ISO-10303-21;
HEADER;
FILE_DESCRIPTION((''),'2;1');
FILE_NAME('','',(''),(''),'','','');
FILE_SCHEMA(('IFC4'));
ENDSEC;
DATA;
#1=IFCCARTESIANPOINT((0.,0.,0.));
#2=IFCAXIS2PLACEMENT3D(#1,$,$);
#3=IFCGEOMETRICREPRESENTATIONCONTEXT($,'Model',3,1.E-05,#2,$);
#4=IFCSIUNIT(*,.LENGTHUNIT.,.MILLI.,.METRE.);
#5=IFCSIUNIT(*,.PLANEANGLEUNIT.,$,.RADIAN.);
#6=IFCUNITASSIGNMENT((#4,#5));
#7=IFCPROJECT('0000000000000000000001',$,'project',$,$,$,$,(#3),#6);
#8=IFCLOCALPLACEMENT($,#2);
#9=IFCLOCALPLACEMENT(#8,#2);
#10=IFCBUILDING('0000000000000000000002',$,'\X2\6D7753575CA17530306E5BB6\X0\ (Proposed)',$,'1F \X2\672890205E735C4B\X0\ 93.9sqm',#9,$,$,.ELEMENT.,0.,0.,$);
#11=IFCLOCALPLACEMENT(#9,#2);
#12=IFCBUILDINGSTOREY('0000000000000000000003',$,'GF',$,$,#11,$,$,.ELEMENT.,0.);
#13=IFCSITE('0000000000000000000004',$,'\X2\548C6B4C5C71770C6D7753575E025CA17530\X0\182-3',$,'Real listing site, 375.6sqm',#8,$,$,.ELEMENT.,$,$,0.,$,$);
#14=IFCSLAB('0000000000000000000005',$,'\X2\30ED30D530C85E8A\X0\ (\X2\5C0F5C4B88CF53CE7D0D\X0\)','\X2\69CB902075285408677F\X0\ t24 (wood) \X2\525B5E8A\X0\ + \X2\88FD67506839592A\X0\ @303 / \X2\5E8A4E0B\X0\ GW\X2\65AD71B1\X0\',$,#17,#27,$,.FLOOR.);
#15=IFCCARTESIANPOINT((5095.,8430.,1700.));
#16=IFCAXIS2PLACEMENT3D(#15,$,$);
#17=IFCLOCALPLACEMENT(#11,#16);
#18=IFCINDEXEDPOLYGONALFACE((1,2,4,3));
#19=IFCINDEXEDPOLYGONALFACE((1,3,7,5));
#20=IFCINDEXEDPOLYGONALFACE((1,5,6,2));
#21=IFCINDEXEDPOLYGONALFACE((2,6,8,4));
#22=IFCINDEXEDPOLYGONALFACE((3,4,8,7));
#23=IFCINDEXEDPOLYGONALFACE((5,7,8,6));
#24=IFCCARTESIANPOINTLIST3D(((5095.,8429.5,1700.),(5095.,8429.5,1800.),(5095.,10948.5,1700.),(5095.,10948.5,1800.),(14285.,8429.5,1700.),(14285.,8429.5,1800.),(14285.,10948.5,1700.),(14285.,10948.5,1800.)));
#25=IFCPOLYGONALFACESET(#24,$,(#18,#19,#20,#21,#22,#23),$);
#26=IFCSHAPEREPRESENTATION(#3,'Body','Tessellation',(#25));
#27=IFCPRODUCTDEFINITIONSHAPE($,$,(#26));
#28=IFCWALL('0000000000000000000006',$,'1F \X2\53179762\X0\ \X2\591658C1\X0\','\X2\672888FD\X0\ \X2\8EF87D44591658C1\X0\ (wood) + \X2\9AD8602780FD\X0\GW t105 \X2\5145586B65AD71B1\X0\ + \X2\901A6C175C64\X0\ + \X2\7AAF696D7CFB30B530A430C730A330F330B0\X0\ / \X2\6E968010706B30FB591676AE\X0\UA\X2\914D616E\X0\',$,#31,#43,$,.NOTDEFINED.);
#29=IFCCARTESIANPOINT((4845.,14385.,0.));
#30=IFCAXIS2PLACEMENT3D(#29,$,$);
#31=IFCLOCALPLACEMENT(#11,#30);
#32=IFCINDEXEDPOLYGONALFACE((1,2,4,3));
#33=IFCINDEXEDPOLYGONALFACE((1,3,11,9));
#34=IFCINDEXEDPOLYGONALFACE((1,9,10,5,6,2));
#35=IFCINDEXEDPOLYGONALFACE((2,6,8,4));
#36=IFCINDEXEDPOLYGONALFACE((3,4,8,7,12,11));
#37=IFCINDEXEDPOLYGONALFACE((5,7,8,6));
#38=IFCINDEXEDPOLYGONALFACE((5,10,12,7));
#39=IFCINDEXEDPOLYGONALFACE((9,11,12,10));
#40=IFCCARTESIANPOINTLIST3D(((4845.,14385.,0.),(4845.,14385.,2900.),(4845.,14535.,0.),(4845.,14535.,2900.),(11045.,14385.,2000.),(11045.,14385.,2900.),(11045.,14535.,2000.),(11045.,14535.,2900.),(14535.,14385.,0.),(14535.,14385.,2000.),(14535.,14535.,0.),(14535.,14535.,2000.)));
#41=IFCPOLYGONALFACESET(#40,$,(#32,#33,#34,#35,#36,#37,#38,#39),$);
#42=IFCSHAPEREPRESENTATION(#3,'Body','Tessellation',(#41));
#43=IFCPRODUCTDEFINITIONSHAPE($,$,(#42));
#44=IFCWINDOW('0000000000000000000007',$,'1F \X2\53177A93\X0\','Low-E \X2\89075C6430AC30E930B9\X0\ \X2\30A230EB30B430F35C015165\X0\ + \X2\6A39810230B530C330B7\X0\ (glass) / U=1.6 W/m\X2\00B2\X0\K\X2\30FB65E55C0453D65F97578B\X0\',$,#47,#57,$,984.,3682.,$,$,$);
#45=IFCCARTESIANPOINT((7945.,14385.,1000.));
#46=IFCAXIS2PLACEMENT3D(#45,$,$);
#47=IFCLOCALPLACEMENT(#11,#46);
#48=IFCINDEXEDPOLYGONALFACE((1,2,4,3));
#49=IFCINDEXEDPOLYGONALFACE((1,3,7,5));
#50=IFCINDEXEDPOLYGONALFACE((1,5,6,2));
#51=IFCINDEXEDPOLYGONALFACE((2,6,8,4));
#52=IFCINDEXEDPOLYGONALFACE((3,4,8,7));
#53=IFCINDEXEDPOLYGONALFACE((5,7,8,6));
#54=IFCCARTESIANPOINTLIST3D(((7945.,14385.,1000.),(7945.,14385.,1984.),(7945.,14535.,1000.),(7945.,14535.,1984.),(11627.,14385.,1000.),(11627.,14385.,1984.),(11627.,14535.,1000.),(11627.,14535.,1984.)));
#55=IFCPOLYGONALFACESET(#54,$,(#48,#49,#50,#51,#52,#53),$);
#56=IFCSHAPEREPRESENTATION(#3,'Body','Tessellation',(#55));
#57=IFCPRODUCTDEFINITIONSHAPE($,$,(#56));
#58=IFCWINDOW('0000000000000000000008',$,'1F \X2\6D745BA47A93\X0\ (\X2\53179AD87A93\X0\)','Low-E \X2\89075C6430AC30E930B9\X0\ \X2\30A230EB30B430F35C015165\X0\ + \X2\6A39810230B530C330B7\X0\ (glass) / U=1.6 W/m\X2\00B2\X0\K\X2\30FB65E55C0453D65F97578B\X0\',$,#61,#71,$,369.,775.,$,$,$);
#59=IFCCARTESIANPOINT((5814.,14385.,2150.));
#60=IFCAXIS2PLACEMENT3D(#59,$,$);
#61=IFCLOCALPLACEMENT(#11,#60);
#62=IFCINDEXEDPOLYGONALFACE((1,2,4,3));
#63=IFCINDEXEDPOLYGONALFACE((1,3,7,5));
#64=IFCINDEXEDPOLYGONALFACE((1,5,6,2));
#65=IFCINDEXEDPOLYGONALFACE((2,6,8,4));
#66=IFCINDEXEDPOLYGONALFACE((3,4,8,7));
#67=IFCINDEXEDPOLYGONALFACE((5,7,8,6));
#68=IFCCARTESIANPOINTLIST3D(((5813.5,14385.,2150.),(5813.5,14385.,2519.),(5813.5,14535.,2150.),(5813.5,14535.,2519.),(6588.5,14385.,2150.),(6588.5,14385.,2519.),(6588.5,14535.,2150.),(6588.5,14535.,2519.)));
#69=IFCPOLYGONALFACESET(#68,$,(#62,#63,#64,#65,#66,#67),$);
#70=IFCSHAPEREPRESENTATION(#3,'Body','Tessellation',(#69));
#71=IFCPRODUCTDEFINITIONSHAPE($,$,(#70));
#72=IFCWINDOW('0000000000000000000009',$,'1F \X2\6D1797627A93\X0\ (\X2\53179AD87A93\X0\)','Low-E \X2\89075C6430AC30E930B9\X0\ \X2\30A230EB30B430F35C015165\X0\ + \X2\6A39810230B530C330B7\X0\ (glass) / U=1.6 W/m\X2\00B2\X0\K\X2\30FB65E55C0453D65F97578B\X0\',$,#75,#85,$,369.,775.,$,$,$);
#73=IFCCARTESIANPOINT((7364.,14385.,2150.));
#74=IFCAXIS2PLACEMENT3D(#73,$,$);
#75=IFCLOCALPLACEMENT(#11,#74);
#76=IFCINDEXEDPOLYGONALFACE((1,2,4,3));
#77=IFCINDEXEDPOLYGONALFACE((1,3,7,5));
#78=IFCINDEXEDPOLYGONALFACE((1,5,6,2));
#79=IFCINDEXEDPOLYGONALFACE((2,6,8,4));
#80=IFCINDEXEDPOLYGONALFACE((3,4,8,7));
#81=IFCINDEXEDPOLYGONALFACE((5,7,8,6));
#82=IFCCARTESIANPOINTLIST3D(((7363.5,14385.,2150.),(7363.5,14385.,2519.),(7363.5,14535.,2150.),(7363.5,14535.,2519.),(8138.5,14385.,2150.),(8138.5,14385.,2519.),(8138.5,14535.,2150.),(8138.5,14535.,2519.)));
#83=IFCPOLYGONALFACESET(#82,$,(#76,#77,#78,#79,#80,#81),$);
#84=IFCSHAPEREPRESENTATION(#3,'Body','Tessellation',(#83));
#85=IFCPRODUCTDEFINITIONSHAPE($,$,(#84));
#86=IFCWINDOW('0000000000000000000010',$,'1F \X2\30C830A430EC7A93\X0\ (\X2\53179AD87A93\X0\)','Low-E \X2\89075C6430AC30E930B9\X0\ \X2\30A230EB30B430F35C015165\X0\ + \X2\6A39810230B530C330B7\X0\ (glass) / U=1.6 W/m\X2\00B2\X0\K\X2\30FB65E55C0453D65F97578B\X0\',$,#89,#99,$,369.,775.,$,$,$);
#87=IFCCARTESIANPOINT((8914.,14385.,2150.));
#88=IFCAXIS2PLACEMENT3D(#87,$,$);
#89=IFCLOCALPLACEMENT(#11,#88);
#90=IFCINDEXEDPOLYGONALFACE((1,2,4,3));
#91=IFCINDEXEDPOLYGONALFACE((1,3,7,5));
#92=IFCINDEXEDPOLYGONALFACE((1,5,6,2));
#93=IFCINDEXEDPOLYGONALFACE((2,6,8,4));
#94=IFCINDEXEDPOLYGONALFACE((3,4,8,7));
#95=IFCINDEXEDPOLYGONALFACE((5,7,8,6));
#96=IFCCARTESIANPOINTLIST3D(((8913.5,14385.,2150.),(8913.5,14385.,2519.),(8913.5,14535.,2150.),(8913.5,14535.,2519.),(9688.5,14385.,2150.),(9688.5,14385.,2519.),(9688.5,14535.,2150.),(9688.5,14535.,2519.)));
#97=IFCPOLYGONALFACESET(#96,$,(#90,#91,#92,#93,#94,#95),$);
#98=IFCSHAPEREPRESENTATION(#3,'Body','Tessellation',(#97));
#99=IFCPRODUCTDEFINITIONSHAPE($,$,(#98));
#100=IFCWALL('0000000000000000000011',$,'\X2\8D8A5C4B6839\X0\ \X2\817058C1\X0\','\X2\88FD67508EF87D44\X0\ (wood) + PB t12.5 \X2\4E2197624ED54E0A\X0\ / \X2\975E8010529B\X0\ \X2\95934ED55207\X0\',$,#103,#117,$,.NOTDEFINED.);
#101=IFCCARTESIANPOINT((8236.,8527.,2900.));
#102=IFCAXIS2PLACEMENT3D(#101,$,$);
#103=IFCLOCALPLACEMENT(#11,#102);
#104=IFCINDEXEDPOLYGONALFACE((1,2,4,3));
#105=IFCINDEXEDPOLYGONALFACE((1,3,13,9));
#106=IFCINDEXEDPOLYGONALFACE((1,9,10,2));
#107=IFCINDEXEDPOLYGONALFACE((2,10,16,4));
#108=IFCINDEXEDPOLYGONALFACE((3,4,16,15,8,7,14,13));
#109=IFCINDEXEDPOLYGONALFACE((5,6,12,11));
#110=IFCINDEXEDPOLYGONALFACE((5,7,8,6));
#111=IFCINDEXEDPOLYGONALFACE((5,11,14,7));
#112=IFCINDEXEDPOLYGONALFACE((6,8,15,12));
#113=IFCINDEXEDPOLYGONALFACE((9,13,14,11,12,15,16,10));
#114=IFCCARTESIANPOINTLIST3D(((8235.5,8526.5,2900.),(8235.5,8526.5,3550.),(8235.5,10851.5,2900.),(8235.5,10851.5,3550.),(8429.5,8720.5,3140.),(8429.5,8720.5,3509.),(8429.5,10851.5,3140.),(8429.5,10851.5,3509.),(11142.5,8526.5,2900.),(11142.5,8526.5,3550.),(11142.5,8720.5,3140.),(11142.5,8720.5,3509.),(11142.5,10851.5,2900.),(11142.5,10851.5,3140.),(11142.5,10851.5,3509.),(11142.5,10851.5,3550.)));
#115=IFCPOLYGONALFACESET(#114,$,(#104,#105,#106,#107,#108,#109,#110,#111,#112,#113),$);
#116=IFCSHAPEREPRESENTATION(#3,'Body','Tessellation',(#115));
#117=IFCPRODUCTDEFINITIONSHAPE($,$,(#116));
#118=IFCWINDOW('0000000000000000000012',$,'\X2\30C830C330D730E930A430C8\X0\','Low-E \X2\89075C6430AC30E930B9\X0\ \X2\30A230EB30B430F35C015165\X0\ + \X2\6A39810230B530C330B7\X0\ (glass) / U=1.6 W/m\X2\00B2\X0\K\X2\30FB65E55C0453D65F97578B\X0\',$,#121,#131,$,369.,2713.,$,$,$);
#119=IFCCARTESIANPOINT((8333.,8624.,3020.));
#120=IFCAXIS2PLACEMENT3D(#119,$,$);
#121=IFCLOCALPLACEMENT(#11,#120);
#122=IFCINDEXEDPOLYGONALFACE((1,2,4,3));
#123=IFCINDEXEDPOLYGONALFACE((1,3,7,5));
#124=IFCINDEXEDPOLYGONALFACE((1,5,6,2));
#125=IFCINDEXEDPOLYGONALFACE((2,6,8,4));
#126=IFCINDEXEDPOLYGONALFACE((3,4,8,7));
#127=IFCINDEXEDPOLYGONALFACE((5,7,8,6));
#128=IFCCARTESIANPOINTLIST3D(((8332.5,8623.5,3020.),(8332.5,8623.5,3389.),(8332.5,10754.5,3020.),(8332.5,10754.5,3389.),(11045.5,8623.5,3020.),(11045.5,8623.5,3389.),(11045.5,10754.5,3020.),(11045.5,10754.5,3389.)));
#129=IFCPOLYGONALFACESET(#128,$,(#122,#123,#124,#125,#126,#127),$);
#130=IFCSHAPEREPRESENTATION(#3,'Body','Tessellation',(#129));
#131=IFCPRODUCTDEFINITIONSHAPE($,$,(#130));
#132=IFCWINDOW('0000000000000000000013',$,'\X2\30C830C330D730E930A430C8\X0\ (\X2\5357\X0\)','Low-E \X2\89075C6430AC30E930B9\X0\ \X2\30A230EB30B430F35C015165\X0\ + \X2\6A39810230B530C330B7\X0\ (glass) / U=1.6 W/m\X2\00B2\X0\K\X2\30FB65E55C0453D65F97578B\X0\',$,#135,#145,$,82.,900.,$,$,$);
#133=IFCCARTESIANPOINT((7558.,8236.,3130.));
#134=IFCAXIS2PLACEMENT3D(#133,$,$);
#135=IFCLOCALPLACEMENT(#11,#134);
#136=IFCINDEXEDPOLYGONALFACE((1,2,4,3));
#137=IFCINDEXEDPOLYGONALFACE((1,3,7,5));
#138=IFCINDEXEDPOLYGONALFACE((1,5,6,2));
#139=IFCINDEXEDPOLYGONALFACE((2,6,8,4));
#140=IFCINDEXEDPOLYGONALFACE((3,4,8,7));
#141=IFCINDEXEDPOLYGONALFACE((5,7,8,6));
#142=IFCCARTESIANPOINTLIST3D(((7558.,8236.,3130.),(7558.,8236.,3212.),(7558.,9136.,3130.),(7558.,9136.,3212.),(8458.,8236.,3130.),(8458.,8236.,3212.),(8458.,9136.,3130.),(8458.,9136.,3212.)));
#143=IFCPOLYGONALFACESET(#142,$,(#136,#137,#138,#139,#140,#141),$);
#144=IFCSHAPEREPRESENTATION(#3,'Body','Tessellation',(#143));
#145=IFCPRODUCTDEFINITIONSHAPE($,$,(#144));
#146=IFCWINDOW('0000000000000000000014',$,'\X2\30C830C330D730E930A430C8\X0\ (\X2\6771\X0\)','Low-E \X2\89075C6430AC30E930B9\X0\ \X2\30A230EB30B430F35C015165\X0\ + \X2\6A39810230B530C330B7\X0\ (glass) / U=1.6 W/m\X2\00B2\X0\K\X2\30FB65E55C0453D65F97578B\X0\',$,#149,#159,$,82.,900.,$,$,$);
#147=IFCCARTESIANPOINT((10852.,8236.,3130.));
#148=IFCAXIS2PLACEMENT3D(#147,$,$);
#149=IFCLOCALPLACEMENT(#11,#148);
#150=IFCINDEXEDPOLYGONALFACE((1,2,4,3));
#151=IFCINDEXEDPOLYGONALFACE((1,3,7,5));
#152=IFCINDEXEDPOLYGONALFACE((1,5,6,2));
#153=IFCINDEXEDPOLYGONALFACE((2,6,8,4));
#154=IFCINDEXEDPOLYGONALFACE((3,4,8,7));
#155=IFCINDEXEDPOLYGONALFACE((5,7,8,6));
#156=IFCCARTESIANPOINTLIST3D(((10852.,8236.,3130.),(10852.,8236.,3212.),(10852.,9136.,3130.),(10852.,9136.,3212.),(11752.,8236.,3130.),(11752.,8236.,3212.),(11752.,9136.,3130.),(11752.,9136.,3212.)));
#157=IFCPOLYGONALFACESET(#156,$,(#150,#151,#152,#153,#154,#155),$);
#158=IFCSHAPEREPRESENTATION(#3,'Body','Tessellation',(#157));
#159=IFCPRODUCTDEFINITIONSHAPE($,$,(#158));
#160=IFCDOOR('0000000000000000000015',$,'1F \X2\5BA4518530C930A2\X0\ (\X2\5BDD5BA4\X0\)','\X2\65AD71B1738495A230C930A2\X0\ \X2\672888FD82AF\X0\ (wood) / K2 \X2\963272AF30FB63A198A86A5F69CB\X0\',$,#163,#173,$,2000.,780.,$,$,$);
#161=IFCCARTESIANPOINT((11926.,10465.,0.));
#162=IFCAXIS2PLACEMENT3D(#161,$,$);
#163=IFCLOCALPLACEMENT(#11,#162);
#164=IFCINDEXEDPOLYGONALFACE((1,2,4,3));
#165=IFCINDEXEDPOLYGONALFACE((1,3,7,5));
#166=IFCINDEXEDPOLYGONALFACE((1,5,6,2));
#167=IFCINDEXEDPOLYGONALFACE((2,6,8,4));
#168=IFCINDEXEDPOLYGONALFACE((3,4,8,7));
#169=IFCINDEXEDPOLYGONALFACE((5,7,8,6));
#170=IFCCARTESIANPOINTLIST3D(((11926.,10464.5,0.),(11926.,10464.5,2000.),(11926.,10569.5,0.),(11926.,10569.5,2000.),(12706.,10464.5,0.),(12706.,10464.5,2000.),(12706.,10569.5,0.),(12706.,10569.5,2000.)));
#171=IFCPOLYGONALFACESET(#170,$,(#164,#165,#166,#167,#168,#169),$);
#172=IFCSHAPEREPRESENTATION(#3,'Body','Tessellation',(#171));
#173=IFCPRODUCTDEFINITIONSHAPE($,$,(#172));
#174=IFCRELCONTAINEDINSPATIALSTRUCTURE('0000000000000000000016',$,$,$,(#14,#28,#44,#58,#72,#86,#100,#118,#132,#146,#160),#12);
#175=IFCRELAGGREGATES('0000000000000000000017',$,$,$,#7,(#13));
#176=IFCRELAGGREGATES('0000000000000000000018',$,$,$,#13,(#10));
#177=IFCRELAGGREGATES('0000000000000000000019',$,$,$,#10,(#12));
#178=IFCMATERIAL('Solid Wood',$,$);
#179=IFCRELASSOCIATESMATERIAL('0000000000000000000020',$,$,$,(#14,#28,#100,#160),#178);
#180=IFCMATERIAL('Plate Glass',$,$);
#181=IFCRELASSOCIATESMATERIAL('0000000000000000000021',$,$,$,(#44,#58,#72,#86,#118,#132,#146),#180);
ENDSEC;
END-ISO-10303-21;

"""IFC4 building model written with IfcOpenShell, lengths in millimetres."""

from ifc_helpers import new_model, si_unit, frame, frame_2d, origin, place, context, project, spatial, rectangle, extrude, material, element, fill, save


model = new_model("IFC4")

# Units and contexts
model_context = context("Model", 3, precision=1e-05, world=origin())
ifc_project = project(units=[si_unit("LENGTHUNIT", "METRE", prefix="MILLI"), si_unit("PLANEANGLEUNIT", "RADIAN")], contexts=[model_context])

# Site, building, storey
site_placement = place(None, origin())
site = spatial("IfcSite", under=ifc_project, at=site_placement, Name="和歌山県海南市岡田182-3", ObjectType="Real listing site, 375.6sqm", CompositionType="ELEMENT", RefElevation=0.0)
building_placement = place(site_placement, origin())
building = spatial("IfcBuilding", under=site, at=building_placement, Name="海南岡田の家 (Proposed)", ObjectType="1F 木造平屋 93.9sqm", CompositionType="ELEMENT", ElevationOfRefHeight=0.0, ElevationOfTerrain=0.0)
storey_placement = place(building_placement, origin())
storey = spatial("IfcBuildingStorey", under=building, at=storey_placement, Name="GF", CompositionType="ELEMENT", Elevation=0.0)

# Slab
ifc_material_1 = material(Name="Solid Wood")
slab_placement = place(storey_placement, frame((5095.0, 8430.0, 1700.0)))
element("IfcSlab", 1, at=slab_placement, inside=storey, material=ifc_material_1, Name="ロフト床 (小屋裏収納)", Description="構造用合板 t24 (wood) 剛床 + 製材根太 @303 / 床下 GW断熱", PredefinedType="FLOOR", context=model_context, shape_type="SweptSolid", body=[
    extrude(rectangle(XDim=9190.0, YDim=2519.0, at=frame_2d((4595.0, 1259.0))), frame((5095.0, 8430.0, 1700.0)), (0.0, 0.0, 1.0), 100.0),
])

# Wall, openings, windows
wall_1_placement = place(storey_placement, frame((4845.0, 14385.0, 0.0)))
wall_1 = element("IfcWall", 2, at=wall_1_placement, inside=storey, material=ifc_material_1, Name="1F 北面 外壁", Description="木製 軸組外壁 (wood) + 高性能GW t105 充填断熱 + 通気層 + 窯業系サイディング / 準耐火・外皮UA配慮", PredefinedType="NOTDEFINED", context=model_context, shape_type="SweptSolid", body=[
    extrude(rectangle(XDim=9690.0, YDim=150.0, at=frame_2d((4845.0, 75.0))), frame((4845.0, 14385.0, 0.0)), (0.0, 0.0, 1.0), 2900.0),
])
opening_1_placement = place(storey_placement, frame((7945.0, 14385.0, 1000.0)))
opening_1 = element("IfcOpeningElement", 3, at=opening_1_placement, cuts=wall_1, PredefinedType="NOTDEFINED", context=model_context, shape_type="SweptSolid", body=[
    extrude(rectangle(XDim=3682.0, YDim=150.0, at=frame_2d((1841.0, 75.0))), frame((7945.0, 14385.0, 1000.0)), (0.0, 0.0, 1.0), 984.0),
])
opening_2_placement = place(storey_placement, frame((5814.0, 14385.0, 2150.0)))
opening_2 = element("IfcOpeningElement", 4, at=opening_2_placement, cuts=wall_1, PredefinedType="NOTDEFINED", context=model_context, shape_type="SweptSolid", body=[
    extrude(rectangle(XDim=775.0, YDim=150.0, at=frame_2d((387.0, 75.0))), frame((5814.0, 14385.0, 2150.0)), (0.0, 0.0, 1.0), 369.0),
])
opening_3_placement = place(storey_placement, frame((7364.0, 14385.0, 2150.0)))
opening_3 = element("IfcOpeningElement", 5, at=opening_3_placement, cuts=wall_1, PredefinedType="NOTDEFINED", context=model_context, shape_type="SweptSolid", body=[
    extrude(rectangle(XDim=775.0, YDim=150.0, at=frame_2d((387.0, 75.0))), frame((7364.0, 14385.0, 2150.0)), (0.0, 0.0, 1.0), 369.0),
])
opening_4_placement = place(storey_placement, frame((8914.0, 14385.0, 2150.0)))
opening_4 = element("IfcOpeningElement", 6, at=opening_4_placement, cuts=wall_1, PredefinedType="NOTDEFINED", context=model_context, shape_type="SweptSolid", body=[
    extrude(rectangle(XDim=775.0, YDim=150.0, at=frame_2d((387.0, 75.0))), frame((8914.0, 14385.0, 2150.0)), (0.0, 0.0, 1.0), 369.0),
])
ifc_material_2 = material(Name="Plate Glass")
window_1_placement = place(storey_placement, frame((7945.0, 14385.0, 1000.0)))
window_1 = element("IfcWindow", 7, at=window_1_placement, inside=storey, material=ifc_material_2, Name="1F 北窓", Description="Low-E 複層ガラス アルゴン封入 + 樹脂サッシ (glass) / U=1.6 W/m²K・日射取得型", OverallHeight=984.0, OverallWidth=3682.0, context=model_context, shape_type="SweptSolid", body=[
    extrude(rectangle(XDim=3682.0, YDim=150.0, at=frame_2d((1841.0, 75.0))), frame((7945.0, 14385.0, 1000.0)), (0.0, 0.0, 1.0), 984.0),
])
fill(opening_1, window_1)
window_2_placement = place(storey_placement, frame((5814.0, 14385.0, 2150.0)))
window_2 = element("IfcWindow", 8, at=window_2_placement, inside=storey, material=ifc_material_2, Name="1F 浴室窓 (北高窓)", Description="Low-E 複層ガラス アルゴン封入 + 樹脂サッシ (glass) / U=1.6 W/m²K・日射取得型", OverallHeight=369.0, OverallWidth=775.0, context=model_context, shape_type="SweptSolid", body=[
    extrude(rectangle(XDim=775.0, YDim=150.0, at=frame_2d((387.0, 75.0))), frame((5814.0, 14385.0, 2150.0)), (0.0, 0.0, 1.0), 369.0),
])
fill(opening_2, window_2)
window_3_placement = place(storey_placement, frame((7364.0, 14385.0, 2150.0)))
window_3 = element("IfcWindow", 9, at=window_3_placement, inside=storey, material=ifc_material_2, Name="1F 洗面窓 (北高窓)", Description="Low-E 複層ガラス アルゴン封入 + 樹脂サッシ (glass) / U=1.6 W/m²K・日射取得型", OverallHeight=369.0, OverallWidth=775.0, context=model_context, shape_type="SweptSolid", body=[
    extrude(rectangle(XDim=775.0, YDim=150.0, at=frame_2d((387.0, 75.0))), frame((7364.0, 14385.0, 2150.0)), (0.0, 0.0, 1.0), 369.0),
])
fill(opening_3, window_3)
window_4_placement = place(storey_placement, frame((8914.0, 14385.0, 2150.0)))
window_4 = element("IfcWindow", 10, at=window_4_placement, inside=storey, material=ifc_material_2, Name="1F トイレ窓 (北高窓)", Description="Low-E 複層ガラス アルゴン封入 + 樹脂サッシ (glass) / U=1.6 W/m²K・日射取得型", OverallHeight=369.0, OverallWidth=775.0, context=model_context, shape_type="SweptSolid", body=[
    extrude(rectangle(XDim=775.0, YDim=150.0, at=frame_2d((387.0, 75.0))), frame((8914.0, 14385.0, 2150.0)), (0.0, 0.0, 1.0), 369.0),
])
fill(opening_4, window_4)

# Wall, openings, windows
wall_2_placement = place(storey_placement, frame((8236.0, 8527.0, 2900.0)))
wall_2 = element("IfcWall", 11, at=wall_2_placement, inside=storey, material=ifc_material_1, Name="越屋根 腰壁", Description="製材軸組 (wood) + PB t12.5 両面仕上 / 非耐力 間仕切", PredefinedType="NOTDEFINED", context=model_context, shape_type="SweptSolid", body=[
    extrude(rectangle(XDim=2907.0, YDim=2325.0, at=frame_2d((1453.0, 1162.0))), frame((8236.0, 8527.0, 2900.0)), (0.0, 0.0, 1.0), 650.0),
])
opening_5_placement = place(storey_placement, frame((8333.0, 8624.0, 3020.0)))
opening_5 = element("IfcOpeningElement", 12, at=opening_5_placement, cuts=wall_2, PredefinedType="NOTDEFINED", context=model_context, shape_type="SweptSolid", body=[
    extrude(rectangle(XDim=2713.0, YDim=2131.0, at=frame_2d((1356.0, 1065.0))), frame((8333.0, 8624.0, 3020.0)), (0.0, 0.0, 1.0), 369.0),
])
opening_6_placement = place(storey_placement, frame((7558.0, 8236.0, 3130.0)))
opening_6 = element("IfcOpeningElement", 13, at=opening_6_placement, cuts=wall_2, PredefinedType="NOTDEFINED", context=model_context, shape_type="SweptSolid", body=[
    extrude(rectangle(XDim=900.0, YDim=900.0, at=frame_2d((450.0, 450.0))), frame((7558.0, 8236.0, 3130.0)), (0.0, 0.0, 1.0), 82.0),
])
opening_7_placement = place(storey_placement, frame((10852.0, 8236.0, 3130.0)))
opening_7 = element("IfcOpeningElement", 14, at=opening_7_placement, cuts=wall_2, PredefinedType="NOTDEFINED", context=model_context, shape_type="SweptSolid", body=[
    extrude(rectangle(XDim=900.0, YDim=900.0, at=frame_2d((450.0, 450.0))), frame((10852.0, 8236.0, 3130.0)), (0.0, 0.0, 1.0), 82.0),
])
window_5_placement = place(storey_placement, frame((8333.0, 8624.0, 3020.0)))
window_5 = element("IfcWindow", 15, at=window_5_placement, inside=storey, material=ifc_material_2, Name="トップライト", Description="Low-E 複層ガラス アルゴン封入 + 樹脂サッシ (glass) / U=1.6 W/m²K・日射取得型", OverallHeight=369.0, OverallWidth=2713.0, context=model_context, shape_type="SweptSolid", body=[
    extrude(rectangle(XDim=2713.0, YDim=2131.0, at=frame_2d((1356.0, 1065.0))), frame((8333.0, 8624.0, 3020.0)), (0.0, 0.0, 1.0), 369.0),
])
fill(opening_5, window_5)
window_6_placement = place(storey_placement, frame((7558.0, 8236.0, 3130.0)))
window_6 = element("IfcWindow", 16, at=window_6_placement, inside=storey, material=ifc_material_2, Name="トップライト (南)", Description="Low-E 複層ガラス アルゴン封入 + 樹脂サッシ (glass) / U=1.6 W/m²K・日射取得型", OverallHeight=82.0, OverallWidth=900.0, context=model_context, shape_type="SweptSolid", body=[
    extrude(rectangle(XDim=900.0, YDim=900.0, at=frame_2d((450.0, 450.0))), frame((7558.0, 8236.0, 3130.0)), (0.0, 0.0, 1.0), 82.0),
])
fill(opening_6, window_6)
window_7_placement = place(storey_placement, frame((10852.0, 8236.0, 3130.0)))
window_7 = element("IfcWindow", 17, at=window_7_placement, inside=storey, material=ifc_material_2, Name="トップライト (東)", Description="Low-E 複層ガラス アルゴン封入 + 樹脂サッシ (glass) / U=1.6 W/m²K・日射取得型", OverallHeight=82.0, OverallWidth=900.0, context=model_context, shape_type="SweptSolid", body=[
    extrude(rectangle(XDim=900.0, YDim=900.0, at=frame_2d((450.0, 450.0))), frame((10852.0, 8236.0, 3130.0)), (0.0, 0.0, 1.0), 82.0),
])
fill(opening_7, window_7)

# Door
door_1_placement = place(storey_placement, frame((11926.0, 10465.0, 0.0)))
element("IfcDoor", 18, at=door_1_placement, inside=storey, material=ifc_material_1, Name="1F 室内ドア (寝室)", Description="断熱玄関ドア 木製芯 (wood) / K2 防犯・採風機構", OverallHeight=2000.0, OverallWidth=780.0, context=model_context, shape_type="SweptSolid", body=[
    extrude(rectangle(XDim=780.0, YDim=105.0, at=frame_2d((390.0, 52.0))), frame((11926.0, 10465.0, 0.0)), (0.0, 0.0, 1.0), 2000.0),
])

save(model, "model.ifc")
